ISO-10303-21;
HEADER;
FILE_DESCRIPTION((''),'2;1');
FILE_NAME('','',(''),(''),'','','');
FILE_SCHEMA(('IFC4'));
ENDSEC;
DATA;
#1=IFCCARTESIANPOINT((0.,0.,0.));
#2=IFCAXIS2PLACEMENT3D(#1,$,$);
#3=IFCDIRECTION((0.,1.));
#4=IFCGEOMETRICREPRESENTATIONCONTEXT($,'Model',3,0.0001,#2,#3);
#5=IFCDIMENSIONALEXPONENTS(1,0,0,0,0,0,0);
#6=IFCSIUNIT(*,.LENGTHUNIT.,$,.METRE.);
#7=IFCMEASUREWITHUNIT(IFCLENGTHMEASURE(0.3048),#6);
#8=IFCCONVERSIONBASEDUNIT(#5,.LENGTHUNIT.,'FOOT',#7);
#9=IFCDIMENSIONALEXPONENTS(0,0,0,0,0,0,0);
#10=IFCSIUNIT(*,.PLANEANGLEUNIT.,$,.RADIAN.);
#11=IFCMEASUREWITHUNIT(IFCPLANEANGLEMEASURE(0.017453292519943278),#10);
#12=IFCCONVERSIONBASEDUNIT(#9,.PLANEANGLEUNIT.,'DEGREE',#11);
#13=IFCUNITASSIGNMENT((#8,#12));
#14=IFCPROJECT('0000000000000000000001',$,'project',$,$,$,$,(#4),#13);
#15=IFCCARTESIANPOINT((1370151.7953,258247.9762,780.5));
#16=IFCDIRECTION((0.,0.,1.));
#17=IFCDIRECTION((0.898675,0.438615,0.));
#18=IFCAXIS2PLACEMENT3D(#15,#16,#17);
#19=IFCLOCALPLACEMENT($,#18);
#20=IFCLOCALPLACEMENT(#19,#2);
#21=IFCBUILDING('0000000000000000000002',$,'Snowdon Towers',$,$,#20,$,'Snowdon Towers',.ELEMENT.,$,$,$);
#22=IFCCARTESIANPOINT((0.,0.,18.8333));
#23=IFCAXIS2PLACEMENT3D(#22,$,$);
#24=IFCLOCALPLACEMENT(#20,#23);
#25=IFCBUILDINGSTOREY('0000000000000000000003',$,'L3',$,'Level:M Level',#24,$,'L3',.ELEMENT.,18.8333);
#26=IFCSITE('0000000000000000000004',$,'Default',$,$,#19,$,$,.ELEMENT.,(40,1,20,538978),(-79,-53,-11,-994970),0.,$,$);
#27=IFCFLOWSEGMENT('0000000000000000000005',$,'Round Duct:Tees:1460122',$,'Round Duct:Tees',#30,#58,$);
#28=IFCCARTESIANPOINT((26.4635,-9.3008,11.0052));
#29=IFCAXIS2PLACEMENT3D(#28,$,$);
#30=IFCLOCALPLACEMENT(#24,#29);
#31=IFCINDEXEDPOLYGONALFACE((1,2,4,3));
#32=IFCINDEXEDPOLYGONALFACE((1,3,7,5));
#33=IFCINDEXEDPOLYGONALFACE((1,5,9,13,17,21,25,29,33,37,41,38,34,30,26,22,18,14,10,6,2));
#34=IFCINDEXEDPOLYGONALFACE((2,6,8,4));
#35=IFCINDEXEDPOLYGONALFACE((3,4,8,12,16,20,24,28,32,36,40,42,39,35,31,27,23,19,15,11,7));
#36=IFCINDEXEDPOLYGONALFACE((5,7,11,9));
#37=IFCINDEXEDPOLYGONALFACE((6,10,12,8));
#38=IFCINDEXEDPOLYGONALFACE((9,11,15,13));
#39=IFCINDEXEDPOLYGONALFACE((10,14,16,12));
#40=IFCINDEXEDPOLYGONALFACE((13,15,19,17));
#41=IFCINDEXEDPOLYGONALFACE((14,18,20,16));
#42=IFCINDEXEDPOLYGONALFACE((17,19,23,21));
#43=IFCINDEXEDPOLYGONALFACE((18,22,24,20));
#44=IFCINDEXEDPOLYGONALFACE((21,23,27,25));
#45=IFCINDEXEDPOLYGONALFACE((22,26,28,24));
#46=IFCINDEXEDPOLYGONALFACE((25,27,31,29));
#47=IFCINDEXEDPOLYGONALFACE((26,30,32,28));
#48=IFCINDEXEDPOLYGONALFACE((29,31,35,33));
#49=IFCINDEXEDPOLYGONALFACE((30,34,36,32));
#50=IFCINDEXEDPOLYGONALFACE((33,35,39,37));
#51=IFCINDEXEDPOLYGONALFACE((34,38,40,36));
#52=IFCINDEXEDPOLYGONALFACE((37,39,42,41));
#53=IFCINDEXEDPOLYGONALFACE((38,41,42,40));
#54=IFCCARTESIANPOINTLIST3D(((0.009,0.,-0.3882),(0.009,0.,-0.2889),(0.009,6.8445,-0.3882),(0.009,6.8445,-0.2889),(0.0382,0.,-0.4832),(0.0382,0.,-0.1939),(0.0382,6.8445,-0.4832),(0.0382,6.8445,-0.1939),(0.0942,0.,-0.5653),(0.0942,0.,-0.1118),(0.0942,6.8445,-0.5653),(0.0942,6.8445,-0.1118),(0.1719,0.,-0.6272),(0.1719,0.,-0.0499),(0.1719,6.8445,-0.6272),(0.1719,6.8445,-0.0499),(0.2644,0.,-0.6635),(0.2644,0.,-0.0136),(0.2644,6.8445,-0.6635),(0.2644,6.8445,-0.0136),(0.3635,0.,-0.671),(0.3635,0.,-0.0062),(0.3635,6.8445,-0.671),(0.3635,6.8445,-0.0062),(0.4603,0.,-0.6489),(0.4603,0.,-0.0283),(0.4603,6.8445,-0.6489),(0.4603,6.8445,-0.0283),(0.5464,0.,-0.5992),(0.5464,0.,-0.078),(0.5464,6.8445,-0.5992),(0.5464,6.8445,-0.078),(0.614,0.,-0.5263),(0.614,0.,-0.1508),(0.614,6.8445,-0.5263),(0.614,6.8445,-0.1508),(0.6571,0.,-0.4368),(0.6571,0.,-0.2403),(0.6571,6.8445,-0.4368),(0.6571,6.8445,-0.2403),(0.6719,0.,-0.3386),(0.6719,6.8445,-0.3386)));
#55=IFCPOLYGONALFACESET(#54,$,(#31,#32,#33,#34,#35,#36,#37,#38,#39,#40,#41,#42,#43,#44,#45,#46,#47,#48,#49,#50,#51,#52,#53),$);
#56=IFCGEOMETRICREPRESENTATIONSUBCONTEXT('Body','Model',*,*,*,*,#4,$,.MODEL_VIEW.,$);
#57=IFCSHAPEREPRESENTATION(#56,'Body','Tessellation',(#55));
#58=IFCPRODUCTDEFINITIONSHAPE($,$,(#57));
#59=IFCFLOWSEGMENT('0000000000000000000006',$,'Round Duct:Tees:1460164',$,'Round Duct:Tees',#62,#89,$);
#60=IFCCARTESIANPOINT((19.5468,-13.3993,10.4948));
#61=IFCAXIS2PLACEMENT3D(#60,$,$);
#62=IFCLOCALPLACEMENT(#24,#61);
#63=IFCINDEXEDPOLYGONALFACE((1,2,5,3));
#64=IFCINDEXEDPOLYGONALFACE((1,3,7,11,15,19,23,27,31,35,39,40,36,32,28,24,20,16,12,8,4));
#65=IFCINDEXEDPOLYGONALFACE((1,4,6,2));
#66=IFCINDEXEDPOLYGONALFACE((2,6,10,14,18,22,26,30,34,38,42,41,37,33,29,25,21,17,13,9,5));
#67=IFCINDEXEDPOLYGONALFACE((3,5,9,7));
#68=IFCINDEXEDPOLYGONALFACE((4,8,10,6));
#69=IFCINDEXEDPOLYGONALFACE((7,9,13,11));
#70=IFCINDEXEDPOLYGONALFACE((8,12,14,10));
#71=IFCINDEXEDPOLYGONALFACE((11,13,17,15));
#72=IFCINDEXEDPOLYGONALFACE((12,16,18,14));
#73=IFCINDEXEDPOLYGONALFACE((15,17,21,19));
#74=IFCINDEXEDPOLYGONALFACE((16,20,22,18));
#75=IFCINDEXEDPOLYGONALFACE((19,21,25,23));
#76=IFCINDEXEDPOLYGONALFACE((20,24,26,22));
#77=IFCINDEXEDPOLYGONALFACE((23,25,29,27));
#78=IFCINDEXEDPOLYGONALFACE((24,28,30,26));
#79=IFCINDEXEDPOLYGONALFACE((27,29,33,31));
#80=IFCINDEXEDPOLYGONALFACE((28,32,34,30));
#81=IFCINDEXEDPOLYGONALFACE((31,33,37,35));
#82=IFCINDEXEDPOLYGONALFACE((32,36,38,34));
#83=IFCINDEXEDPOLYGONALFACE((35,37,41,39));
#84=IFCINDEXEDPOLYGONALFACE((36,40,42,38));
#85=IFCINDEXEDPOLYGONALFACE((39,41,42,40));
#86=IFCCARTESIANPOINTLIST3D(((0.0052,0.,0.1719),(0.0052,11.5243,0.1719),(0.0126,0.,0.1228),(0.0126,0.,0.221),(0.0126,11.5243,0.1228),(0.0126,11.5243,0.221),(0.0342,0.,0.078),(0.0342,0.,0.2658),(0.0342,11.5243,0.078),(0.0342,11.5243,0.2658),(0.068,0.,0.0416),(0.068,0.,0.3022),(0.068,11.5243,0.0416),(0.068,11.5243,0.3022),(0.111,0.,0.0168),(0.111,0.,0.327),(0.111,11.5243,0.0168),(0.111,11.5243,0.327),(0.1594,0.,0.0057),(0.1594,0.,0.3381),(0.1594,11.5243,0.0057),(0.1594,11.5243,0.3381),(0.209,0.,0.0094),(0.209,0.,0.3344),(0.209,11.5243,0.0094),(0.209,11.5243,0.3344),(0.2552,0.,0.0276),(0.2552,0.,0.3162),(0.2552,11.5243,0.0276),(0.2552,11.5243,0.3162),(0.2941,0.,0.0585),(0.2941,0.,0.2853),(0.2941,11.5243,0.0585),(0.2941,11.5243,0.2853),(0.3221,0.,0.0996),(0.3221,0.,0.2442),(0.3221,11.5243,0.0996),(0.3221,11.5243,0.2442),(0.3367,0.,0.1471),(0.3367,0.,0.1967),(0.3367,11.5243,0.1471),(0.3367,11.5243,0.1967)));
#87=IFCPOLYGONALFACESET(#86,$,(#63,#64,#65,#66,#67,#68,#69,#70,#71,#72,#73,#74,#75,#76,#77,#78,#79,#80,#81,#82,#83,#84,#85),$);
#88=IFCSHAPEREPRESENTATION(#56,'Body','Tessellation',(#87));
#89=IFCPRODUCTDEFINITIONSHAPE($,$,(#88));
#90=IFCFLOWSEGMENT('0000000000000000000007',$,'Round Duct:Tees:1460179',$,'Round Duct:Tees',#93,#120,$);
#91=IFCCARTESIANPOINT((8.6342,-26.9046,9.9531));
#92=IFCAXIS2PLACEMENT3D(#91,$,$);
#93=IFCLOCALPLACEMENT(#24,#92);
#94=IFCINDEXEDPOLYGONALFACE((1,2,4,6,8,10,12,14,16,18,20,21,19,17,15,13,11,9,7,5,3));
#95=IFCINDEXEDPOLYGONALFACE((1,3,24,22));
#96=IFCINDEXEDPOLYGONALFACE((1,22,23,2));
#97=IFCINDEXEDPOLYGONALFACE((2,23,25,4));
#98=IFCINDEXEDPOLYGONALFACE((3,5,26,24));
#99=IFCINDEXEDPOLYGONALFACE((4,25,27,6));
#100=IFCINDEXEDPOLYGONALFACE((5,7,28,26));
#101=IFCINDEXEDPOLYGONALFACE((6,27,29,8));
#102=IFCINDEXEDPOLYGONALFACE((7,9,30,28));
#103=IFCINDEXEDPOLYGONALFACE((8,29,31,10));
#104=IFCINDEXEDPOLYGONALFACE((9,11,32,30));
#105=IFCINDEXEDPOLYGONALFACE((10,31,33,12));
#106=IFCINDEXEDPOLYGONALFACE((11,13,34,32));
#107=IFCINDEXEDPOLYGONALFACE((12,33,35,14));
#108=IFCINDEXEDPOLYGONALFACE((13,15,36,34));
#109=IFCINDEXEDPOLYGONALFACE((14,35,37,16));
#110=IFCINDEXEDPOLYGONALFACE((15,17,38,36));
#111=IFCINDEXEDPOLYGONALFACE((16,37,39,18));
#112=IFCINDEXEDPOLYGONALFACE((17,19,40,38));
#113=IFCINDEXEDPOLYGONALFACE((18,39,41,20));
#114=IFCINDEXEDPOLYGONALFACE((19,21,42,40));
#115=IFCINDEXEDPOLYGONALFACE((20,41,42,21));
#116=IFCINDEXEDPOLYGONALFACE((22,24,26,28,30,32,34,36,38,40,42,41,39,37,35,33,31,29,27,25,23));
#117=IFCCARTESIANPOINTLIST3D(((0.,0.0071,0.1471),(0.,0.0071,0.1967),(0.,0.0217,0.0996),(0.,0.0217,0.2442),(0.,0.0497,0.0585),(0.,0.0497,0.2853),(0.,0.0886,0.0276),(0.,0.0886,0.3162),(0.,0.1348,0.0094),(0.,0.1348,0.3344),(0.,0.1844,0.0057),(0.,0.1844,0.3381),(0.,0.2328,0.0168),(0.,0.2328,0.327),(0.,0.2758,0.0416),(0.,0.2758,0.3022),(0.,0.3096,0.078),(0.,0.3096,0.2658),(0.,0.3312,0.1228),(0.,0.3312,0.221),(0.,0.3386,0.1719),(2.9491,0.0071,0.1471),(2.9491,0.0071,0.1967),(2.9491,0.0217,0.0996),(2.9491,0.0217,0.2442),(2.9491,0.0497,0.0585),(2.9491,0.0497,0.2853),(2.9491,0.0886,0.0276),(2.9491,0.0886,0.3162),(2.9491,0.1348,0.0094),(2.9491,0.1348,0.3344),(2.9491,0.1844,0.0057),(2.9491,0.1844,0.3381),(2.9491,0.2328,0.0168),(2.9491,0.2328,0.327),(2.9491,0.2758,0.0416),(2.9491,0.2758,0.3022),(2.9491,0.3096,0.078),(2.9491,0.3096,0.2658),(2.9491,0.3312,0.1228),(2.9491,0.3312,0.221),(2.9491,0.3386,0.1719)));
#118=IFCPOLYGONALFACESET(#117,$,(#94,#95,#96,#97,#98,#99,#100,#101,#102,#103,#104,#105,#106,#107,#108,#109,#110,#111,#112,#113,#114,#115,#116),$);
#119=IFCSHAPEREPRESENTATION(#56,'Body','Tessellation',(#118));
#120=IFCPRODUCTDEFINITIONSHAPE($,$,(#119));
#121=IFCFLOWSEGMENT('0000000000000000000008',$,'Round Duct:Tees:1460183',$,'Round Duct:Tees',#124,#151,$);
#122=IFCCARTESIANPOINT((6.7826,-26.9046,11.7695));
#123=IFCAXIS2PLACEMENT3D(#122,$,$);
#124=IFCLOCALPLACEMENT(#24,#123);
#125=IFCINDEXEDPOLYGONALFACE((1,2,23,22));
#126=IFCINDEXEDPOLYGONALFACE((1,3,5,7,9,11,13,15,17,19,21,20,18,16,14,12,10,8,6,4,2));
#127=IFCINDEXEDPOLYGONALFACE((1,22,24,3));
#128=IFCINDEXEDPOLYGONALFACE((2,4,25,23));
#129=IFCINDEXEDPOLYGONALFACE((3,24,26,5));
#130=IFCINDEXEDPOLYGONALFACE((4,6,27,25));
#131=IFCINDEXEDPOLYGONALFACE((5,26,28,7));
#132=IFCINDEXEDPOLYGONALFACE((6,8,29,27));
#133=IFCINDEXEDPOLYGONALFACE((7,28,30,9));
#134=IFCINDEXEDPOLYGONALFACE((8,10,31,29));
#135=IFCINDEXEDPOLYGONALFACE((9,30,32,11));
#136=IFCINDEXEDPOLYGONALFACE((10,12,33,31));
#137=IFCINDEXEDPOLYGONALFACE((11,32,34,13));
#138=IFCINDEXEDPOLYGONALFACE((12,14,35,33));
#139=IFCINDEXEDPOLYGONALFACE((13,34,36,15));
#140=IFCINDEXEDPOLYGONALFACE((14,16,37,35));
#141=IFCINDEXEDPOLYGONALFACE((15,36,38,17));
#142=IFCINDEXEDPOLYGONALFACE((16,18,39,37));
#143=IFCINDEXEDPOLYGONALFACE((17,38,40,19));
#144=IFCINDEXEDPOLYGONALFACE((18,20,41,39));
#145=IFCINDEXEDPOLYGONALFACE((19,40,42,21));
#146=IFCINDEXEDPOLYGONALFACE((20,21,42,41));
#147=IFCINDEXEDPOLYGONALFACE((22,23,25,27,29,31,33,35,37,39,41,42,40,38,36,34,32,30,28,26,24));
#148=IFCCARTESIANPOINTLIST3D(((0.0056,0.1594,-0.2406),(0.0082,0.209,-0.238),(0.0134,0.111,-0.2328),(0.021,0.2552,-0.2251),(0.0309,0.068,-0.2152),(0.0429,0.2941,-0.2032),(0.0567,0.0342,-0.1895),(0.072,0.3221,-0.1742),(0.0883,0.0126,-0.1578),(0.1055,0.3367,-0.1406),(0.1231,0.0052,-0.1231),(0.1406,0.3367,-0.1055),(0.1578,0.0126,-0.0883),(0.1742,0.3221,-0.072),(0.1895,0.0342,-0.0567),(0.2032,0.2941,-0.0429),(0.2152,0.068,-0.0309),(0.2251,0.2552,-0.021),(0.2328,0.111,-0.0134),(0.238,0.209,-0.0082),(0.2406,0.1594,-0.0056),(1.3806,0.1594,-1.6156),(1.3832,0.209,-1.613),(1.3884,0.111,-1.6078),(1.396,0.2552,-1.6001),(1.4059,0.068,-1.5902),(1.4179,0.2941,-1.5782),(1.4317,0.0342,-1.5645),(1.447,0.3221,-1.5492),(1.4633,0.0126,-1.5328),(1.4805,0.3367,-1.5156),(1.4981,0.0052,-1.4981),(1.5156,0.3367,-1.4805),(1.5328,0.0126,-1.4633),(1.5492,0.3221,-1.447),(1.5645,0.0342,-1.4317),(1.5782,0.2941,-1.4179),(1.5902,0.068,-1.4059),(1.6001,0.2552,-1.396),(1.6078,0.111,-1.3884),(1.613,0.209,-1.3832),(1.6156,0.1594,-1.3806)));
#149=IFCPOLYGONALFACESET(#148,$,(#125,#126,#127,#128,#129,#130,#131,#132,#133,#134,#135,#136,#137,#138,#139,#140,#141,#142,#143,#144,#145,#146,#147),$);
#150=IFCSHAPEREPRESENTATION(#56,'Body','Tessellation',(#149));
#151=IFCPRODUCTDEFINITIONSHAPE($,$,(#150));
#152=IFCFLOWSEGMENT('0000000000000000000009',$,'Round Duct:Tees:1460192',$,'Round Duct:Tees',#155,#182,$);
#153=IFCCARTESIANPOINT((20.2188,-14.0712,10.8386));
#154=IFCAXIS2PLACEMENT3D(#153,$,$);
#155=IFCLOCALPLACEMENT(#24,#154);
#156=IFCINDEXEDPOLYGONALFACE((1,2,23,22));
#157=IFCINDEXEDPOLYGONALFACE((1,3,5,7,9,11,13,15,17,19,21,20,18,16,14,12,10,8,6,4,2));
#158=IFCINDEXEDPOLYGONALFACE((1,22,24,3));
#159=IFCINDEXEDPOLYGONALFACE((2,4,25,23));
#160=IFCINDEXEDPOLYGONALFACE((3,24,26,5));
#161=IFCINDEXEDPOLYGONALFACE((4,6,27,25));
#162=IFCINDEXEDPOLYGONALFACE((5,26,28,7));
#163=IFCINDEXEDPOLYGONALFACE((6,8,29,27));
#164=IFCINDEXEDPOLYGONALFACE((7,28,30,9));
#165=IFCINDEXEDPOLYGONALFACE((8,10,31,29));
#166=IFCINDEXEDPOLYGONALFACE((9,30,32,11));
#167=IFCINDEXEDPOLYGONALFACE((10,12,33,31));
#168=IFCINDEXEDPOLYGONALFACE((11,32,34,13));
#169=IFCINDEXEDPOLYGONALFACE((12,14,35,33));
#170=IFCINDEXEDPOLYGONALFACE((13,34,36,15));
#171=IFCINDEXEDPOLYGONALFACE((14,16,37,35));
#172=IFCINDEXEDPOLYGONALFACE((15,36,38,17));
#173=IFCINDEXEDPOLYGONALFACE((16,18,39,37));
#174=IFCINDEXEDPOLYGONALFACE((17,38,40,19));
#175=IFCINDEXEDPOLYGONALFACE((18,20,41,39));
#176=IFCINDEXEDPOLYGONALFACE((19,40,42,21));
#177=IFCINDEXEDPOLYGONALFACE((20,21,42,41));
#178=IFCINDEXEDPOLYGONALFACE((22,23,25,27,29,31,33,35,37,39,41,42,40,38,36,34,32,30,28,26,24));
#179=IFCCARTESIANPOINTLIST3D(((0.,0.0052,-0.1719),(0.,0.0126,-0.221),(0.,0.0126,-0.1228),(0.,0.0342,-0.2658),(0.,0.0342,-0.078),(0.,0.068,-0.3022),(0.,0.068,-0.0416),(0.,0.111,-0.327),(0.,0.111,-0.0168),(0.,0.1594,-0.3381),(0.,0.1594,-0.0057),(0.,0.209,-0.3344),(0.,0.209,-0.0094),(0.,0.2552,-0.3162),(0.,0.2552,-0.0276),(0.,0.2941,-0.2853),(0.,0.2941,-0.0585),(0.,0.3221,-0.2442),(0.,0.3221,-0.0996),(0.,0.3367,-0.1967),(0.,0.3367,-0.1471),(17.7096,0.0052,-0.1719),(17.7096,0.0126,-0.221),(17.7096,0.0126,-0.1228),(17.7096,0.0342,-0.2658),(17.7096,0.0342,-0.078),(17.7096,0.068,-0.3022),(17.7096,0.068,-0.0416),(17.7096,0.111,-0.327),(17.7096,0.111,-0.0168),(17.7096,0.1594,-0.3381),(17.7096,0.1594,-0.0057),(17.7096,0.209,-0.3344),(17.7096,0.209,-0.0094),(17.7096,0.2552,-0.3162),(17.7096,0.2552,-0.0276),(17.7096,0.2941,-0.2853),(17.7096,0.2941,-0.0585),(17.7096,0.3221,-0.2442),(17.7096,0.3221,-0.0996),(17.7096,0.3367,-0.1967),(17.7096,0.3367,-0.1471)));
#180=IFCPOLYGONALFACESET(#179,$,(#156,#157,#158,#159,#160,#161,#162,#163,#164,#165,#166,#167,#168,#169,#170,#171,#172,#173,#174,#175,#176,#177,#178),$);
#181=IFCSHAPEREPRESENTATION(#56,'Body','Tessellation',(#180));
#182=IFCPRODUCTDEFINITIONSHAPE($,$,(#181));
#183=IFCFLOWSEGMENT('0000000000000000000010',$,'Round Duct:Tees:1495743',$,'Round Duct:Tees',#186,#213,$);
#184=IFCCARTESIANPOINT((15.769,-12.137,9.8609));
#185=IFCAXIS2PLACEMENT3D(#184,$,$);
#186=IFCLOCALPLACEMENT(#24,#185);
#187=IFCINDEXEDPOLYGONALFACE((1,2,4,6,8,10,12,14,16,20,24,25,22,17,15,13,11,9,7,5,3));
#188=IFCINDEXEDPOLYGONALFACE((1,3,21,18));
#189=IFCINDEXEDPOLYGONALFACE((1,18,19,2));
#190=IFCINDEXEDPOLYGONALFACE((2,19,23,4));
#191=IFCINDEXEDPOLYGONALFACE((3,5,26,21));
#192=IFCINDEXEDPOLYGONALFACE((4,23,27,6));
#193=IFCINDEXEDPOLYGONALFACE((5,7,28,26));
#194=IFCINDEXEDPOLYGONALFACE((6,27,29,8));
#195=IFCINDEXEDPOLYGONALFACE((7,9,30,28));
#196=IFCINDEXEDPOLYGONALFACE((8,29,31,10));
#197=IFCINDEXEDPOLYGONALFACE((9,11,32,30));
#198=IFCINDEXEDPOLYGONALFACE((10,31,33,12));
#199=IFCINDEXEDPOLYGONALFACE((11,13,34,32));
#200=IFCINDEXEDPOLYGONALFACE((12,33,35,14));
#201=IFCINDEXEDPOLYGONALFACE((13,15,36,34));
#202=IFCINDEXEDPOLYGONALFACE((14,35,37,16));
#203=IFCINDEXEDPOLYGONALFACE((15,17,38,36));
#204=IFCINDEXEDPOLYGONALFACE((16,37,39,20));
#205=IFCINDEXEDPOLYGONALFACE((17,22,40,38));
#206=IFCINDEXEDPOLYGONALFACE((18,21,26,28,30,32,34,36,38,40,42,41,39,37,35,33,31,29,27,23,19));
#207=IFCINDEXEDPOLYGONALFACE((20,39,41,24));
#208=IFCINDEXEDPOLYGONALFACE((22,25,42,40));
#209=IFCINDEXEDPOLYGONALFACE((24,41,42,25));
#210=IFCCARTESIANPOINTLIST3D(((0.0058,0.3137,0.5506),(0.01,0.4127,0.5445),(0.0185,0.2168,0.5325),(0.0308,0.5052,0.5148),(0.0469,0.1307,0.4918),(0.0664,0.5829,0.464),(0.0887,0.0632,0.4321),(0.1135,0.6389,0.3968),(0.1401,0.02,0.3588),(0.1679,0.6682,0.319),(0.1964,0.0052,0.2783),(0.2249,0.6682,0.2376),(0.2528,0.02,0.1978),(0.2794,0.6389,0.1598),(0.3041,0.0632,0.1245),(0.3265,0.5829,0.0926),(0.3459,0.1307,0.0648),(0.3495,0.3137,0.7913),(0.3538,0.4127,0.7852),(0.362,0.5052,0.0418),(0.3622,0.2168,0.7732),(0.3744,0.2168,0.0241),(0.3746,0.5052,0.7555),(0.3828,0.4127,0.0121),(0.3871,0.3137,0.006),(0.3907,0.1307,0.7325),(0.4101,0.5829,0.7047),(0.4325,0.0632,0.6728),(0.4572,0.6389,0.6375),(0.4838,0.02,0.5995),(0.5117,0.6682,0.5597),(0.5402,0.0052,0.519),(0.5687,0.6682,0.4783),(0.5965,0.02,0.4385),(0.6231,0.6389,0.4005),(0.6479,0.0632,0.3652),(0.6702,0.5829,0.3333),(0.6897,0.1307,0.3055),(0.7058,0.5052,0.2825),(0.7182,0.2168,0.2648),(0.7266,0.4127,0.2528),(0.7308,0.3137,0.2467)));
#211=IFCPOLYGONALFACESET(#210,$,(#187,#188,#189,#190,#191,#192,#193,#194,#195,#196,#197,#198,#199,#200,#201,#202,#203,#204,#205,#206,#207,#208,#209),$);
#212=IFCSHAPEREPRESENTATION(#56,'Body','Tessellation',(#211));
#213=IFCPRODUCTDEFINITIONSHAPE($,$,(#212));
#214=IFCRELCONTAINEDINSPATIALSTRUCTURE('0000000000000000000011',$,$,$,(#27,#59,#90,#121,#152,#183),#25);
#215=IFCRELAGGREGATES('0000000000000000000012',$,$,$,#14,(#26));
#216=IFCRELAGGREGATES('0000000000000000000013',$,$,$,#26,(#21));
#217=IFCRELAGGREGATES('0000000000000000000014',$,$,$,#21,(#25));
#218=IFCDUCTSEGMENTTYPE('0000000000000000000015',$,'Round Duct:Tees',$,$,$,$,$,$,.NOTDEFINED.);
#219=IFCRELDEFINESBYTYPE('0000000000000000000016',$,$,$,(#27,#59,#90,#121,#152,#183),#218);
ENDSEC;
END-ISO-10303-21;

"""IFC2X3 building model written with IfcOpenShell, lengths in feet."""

from ifc_helpers import new_model, entity, si_unit, converted_unit, direction, frame, frame_2d, origin, origin_2d_with_axis, place, context, subcontext, project, spatial, circle, extrude, type_object, element, save


model = new_model("IFC2X3")

# Units and contexts
model_context = context("Model", 3, precision=0.0001, world=origin(), true_north=direction((0.0, 1.0)))
body_context = subcontext(model_context, "Body", "Model", "MODEL_VIEW")
ifc_project = project(units=[converted_unit("LENGTHUNIT", "FOOT", entity("IfcLengthMeasure", 0.3048), si_unit("LENGTHUNIT", "METRE"), dimensions=[1, 0, 0, 0, 0, 0, 0]), converted_unit("PLANEANGLEUNIT", "DEGREE", entity("IfcPlaneAngleMeasure", 0.017453292519943278), si_unit("PLANEANGLEUNIT", "RADIAN"), dimensions=[0, 0, 0, 0, 0, 0, 0])], contexts=[model_context])

# Site, building, storey
site_placement = place(None, frame((1370151.7953, 258247.9762, 780.5), z_axis=(0.0, 0.0, 1.0), x_axis=(0.898675, 0.438615, 0.0)))
site = spatial("IfcSite", under=ifc_project, at=site_placement, Name="Default", CompositionType="ELEMENT", RefLatitude=(40, 1, 20, 538978), RefLongitude=(-79, -53, -11, -994970), RefElevation=0.0)
building_placement = place(site_placement, origin())
building = spatial("IfcBuilding", under=site, at=building_placement, Name="Snowdon Towers", LongName="Snowdon Towers", CompositionType="ELEMENT")
storey_placement = place(building_placement, frame((0.0, 0.0, 18.8333)))
storey = spatial("IfcBuildingStorey", under=building, at=storey_placement, Name="L3", ObjectType="Level:M Level", LongName="L3", CompositionType="ELEMENT", Elevation=18.8333)

# Flow segments
duct_segment_type = type_object("IfcDuctSegmentType", Name="Round Duct:Tees", PredefinedType="NOTDEFINED")
flow_segment_1_placement = place(storey_placement, frame((26.4635, -9.3008, 11.0052)))
element("IfcFlowSegment", 1, at=flow_segment_1_placement, inside=storey, type_object=duct_segment_type, Name="Round Duct:Tees:1460122", ObjectType="Round Duct:Tees", context=body_context, shape_type="SweptSolid", body=[
    extrude(circle(Radius=0.3333, at=origin_2d_with_axis()), frame((0.3386, 0.0, -0.3386), z_axis=(0.0, 1.0, 0.0), x_axis=(1.0, 0.0, 0.0)), (0.0, 0.0, 1.0), 6.8445),
])
flow_segment_2_placement = place(storey_placement, frame((19.5468, -13.3993, 10.4948)))
element("IfcFlowSegment", 2, at=flow_segment_2_placement, inside=storey, type_object=duct_segment_type, Name="Round Duct:Tees:1460164", ObjectType="Round Duct:Tees", context=body_context, shape_type="SweptSolid", body=[
    extrude(circle(Radius=0.1667, at=frame_2d((0.0, 0.0), x_axis=(1.0, 0.0))), frame((0.1719, 0.0, 0.1719), z_axis=(0.0, 1.0, 0.0), x_axis=(-1.0, 0.0, 0.0)), (0.0, 0.0, 1.0), 11.5243),
])
flow_segment_3_placement = place(storey_placement, frame((8.6342, -26.9046, 9.9531)))
element("IfcFlowSegment", 3, at=flow_segment_3_placement, inside=storey, type_object=duct_segment_type, Name="Round Duct:Tees:1460179", ObjectType="Round Duct:Tees", context=body_context, shape_type="SweptSolid", body=[
    extrude(circle(Radius=0.1667, at=origin_2d_with_axis()), frame((0.0, 0.1719, 0.1719), z_axis=(1.0, 0.0, 0.0), x_axis=(0.0, 1.0, 0.0)), (0.0, 0.0, 1.0), 2.9491),
])
flow_segment_4_placement = place(storey_placement, frame((6.7826, -26.9046, 11.7695)))
element("IfcFlowSegment", 4, at=flow_segment_4_placement, inside=storey, type_object=duct_segment_type, Name="Round Duct:Tees:1460183", ObjectType="Round Duct:Tees", context=body_context, shape_type="SweptSolid", body=[
    extrude(circle(Radius=0.1667, at=frame_2d((0.0, 0.0), x_axis=(1.0, 0.0))), frame((1.4981, 0.1719, -1.4981), z_axis=(-0.707107, 0.0, 0.707107), x_axis=(0.0, -1.0, 0.0)), (0.0, 0.0, 1.0), 1.9445),
])
flow_segment_5_placement = place(storey_placement, frame((20.2188, -14.0712, 10.8386)))
element("IfcFlowSegment", 5, at=flow_segment_5_placement, inside=storey, type_object=duct_segment_type, Name="Round Duct:Tees:1460192", ObjectType="Round Duct:Tees", context=body_context, shape_type="SweptSolid", body=[
    extrude(circle(Radius=0.1667, at=frame_2d((0.0, 0.0), x_axis=(1.0, 0.0))), frame((0.0, 0.1719, -0.1719), z_axis=(1.0, 0.0, 0.0), x_axis=(0.0, -1.0, 0.0)), (0.0, 0.0, 1.0), 17.7096),
])
flow_segment_6_placement = place(storey_placement, frame((15.769, -12.137, 9.8609)))
element("IfcFlowSegment", 6, at=flow_segment_6_placement, inside=storey, type_object=duct_segment_type, Name="Round Duct:Tees:1495743", ObjectType="Round Duct:Tees", context=body_context, shape_type="SweptSolid", body=[
    extrude(circle(Radius=0.3333, at=frame_2d((0.0, 0.0), x_axis=(1.0, 0.0))), frame((0.1964, 0.3386, 0.2783), z_axis=(0.819152, 0.0, 0.573576), x_axis=(0.0, -1.0, 0.0)), (0.0, 0.0, 1.0), 0.4196),
])

save(model, "model.ifc")
